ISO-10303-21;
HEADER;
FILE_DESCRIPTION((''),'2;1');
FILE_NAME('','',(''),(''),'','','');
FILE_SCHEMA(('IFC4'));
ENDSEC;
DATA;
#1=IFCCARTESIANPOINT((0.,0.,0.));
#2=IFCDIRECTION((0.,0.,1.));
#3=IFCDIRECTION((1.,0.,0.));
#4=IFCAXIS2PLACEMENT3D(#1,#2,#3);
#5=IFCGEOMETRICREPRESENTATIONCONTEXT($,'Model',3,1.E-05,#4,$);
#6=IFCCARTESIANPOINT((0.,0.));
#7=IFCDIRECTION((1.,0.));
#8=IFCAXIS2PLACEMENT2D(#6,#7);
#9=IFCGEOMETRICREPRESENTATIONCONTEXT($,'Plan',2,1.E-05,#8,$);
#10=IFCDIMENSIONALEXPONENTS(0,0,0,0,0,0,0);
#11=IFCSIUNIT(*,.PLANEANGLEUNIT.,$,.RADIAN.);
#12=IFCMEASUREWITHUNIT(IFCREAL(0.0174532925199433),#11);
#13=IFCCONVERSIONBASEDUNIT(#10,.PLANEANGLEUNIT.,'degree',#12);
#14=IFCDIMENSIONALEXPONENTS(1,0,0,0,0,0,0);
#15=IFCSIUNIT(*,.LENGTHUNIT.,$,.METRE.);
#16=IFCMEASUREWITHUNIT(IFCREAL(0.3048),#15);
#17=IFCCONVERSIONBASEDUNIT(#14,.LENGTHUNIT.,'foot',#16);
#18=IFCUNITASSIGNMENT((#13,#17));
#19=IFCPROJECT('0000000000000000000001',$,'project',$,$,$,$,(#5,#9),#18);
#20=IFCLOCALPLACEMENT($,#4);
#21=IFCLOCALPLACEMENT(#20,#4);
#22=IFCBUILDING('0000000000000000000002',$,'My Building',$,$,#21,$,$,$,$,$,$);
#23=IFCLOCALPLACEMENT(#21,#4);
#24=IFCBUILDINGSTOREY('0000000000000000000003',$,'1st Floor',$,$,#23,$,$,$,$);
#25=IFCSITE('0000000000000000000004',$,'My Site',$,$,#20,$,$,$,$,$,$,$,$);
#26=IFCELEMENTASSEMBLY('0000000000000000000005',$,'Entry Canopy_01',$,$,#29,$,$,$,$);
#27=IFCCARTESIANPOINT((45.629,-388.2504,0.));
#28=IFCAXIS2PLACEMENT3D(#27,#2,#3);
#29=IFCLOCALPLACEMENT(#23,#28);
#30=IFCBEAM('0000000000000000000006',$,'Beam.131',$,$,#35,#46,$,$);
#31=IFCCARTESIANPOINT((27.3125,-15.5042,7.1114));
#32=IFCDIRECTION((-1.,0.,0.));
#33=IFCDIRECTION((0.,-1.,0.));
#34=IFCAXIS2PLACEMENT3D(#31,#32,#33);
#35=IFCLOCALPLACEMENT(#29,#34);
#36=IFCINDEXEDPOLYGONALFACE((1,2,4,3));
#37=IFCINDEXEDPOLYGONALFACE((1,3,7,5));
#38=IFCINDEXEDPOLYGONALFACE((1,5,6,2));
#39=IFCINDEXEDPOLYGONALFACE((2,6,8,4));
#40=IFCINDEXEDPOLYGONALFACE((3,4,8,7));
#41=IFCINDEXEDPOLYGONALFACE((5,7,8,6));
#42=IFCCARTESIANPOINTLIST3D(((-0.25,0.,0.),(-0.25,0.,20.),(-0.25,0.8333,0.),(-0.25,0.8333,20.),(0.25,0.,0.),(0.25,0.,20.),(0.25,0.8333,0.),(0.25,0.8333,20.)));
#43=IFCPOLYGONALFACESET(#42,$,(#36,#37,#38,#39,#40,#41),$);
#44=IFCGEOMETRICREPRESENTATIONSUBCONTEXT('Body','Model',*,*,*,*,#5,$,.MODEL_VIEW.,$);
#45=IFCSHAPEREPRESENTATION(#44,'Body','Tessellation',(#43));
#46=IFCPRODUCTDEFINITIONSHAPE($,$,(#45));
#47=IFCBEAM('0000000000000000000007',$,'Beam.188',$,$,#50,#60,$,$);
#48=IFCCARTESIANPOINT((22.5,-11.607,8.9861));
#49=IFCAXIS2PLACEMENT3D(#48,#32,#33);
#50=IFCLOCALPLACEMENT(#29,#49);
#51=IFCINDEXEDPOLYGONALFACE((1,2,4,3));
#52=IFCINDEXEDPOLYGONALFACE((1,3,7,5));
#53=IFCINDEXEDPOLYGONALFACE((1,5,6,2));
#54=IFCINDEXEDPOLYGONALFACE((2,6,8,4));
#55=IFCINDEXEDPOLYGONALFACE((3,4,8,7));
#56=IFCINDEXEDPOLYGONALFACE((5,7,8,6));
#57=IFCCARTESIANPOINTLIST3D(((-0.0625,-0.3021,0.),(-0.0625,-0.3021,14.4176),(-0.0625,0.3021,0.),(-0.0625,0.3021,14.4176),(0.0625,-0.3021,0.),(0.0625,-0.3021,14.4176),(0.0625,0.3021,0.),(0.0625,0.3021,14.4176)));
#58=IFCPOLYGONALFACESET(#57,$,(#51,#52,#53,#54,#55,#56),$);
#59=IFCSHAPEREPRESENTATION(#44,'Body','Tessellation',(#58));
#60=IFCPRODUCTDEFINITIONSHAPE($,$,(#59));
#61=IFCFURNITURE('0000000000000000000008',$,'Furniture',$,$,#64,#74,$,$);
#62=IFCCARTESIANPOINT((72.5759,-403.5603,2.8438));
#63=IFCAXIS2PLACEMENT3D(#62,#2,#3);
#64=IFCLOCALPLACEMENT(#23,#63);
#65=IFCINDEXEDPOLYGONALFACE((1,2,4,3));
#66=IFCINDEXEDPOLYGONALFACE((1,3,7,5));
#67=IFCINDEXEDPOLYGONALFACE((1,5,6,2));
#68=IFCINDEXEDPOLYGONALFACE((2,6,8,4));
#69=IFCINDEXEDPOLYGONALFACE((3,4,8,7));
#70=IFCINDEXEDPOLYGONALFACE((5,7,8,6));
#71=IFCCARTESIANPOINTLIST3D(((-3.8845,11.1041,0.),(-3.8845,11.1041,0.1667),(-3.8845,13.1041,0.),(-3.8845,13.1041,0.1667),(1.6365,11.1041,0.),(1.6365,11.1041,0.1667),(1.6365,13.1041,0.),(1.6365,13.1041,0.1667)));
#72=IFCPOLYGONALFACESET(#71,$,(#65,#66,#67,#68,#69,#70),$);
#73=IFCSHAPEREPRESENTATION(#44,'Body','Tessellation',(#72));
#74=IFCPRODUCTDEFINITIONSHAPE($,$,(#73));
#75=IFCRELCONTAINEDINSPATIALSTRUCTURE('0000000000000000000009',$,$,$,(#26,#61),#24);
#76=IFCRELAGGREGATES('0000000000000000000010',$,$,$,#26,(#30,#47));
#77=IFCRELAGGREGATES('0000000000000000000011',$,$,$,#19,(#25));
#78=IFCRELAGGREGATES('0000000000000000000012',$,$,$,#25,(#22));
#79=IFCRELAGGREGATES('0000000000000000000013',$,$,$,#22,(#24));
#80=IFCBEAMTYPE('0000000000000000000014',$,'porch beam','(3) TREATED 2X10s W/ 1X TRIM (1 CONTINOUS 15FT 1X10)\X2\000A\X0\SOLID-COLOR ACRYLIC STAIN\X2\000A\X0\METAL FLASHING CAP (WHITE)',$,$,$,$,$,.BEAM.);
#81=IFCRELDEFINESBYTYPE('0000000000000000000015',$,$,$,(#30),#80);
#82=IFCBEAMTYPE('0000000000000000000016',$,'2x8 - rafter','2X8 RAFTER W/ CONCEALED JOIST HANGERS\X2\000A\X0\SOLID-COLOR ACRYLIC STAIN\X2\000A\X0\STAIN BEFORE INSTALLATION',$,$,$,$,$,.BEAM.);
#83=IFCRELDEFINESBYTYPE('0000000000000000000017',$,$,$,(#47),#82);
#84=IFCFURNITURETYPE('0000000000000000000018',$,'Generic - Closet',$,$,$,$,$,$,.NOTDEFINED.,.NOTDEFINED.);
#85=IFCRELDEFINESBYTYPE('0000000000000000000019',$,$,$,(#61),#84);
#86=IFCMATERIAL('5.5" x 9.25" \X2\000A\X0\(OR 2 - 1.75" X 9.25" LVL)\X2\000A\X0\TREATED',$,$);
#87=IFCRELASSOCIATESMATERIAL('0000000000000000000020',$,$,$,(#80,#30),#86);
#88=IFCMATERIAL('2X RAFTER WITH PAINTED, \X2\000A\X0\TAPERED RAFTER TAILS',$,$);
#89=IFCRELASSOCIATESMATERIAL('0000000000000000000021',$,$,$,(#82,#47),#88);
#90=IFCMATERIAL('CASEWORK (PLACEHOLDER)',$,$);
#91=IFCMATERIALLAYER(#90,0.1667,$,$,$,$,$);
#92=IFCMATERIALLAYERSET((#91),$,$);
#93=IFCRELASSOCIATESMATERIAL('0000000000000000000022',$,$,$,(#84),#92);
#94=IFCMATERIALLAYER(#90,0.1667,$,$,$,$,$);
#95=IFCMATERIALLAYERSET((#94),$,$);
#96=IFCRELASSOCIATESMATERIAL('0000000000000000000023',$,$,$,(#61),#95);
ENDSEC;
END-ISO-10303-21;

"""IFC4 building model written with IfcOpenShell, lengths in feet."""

from ifc_helpers import new_model, entity, si_unit, converted_unit, frame, origin_with_axes, origin_2d_with_axis, place, context, subcontext, project, spatial, indexed_curve, rectangle, outline, extrude, material, layer, layer_set, layer_usage, material_profile, profile_set, profile_usage, type_object, element, aggregate, save


model = new_model("IFC4")

# Units and contexts
model_context = context("Model", 3, precision=1e-05, world=origin_with_axes())
plan_context = context("Plan", 2, precision=1e-05, world=origin_2d_with_axis())
body_context = subcontext(model_context, "Body", "Model", "MODEL_VIEW")
ifc_project = project(units=[converted_unit("PLANEANGLEUNIT", "degree", entity("IfcReal", 0.0174532925199433), si_unit("PLANEANGLEUNIT", "RADIAN"), dimensions=[0, 0, 0, 0, 0, 0, 0]), converted_unit("LENGTHUNIT", "foot", entity("IfcReal", 0.3048), si_unit("LENGTHUNIT", "METRE"), dimensions=[1, 0, 0, 0, 0, 0, 0])], contexts=[model_context, plan_context])

# Site, building, storey
site_placement = place(None, origin_with_axes())
site = spatial("IfcSite", under=ifc_project, at=site_placement, Name="My Site")
building_placement = place(site_placement, origin_with_axes())
building = spatial("IfcBuilding", under=site, at=building_placement, Name="My Building")
storey_placement = place(building_placement, origin_with_axes())
storey = spatial("IfcBuildingStorey", under=building, at=storey_placement, Name="1st Floor")

# Element assembly
assembly_1_placement = place(storey_placement, frame((45.629, -388.2504, 0.0), z_axis=(0.0, 0.0, 1.0), x_axis=(1.0, 0.0, 0.0)))
assembly_1 = element("IfcElementAssembly", 1, at=assembly_1_placement, inside=storey, Name="Entry Canopy_01")

# Beam
ifc_material_1 = material(Name="5.5\" x 9.25\" \n(OR 2 - 1.75\" X 9.25\" LVL)\nTREATED")
ifc_material_profile_1 = material_profile(ifc_material_1, rectangle(XDim=0.5, YDim=0.8333))
ifc_profile_set_1 = profile_set([ifc_material_profile_1])
ifc_profile_usage_1 = profile_usage(ifc_profile_set_1, cardinal=2)
beam_type_1 = type_object("IfcBeamType", Name="porch beam", Description="(3) TREATED 2X10s W/ 1X TRIM (1 CONTINOUS 15FT 1X10)\nSOLID-COLOR ACRYLIC STAIN\nMETAL FLASHING CAP (WHITE)", PredefinedType="BEAM", material=ifc_profile_set_1)
beam_1_placement = place(assembly_1_placement, frame((27.3125, -15.5042, 7.1114), z_axis=(-1.0, 0.0, 0.0), x_axis=(0.0, -1.0, 0.0)))
beam_1 = element("IfcBeam", 2, at=beam_1_placement, type_object=beam_type_1, material=ifc_profile_usage_1, Name="Beam.131", context=body_context, shape_type="SweptSolid", body=[
    extrude(rectangle(XDim=0.5, YDim=0.8333), frame((0.0, 0.4167, 0.0), z_axis=(0.0, 0.0, 1.0), x_axis=(1.0, 0.0, 0.0)), (0.0, 0.0, 1.0), 20.0),
])
ifc_material_2 = material(Name="2X RAFTER WITH PAINTED, \nTAPERED RAFTER TAILS")
ifc_material_profile_2 = material_profile(ifc_material_2, rectangle(XDim=0.125, YDim=0.6042))
ifc_profile_set_2 = profile_set([ifc_material_profile_2])
ifc_material_profile_3 = material_profile(ifc_material_2, rectangle(XDim=0.125, YDim=0.6042))
ifc_profile_set_3 = profile_set([ifc_material_profile_3])
beam_type_2 = type_object("IfcBeamType", Name="2x8 - rafter", Description="2X8 RAFTER W/ CONCEALED JOIST HANGERS\nSOLID-COLOR ACRYLIC STAIN\nSTAIN BEFORE INSTALLATION", PredefinedType="BEAM", material=ifc_profile_set_3)

# Beam
ifc_profile_usage_2 = profile_usage(ifc_profile_set_2)
beam_2_placement = place(assembly_1_placement, frame((22.5, -11.607, 8.9861), z_axis=(-1.0, 0.0, 0.0), x_axis=(0.0, -1.0, 0.0)))
beam_2 = element("IfcBeam", 3, at=beam_2_placement, type_object=beam_type_2, material=ifc_profile_usage_2, Name="Beam.188", context=body_context, shape_type="SweptSolid", body=[
    extrude(rectangle(XDim=0.125, YDim=0.6042), origin_with_axes(), (0.0, 0.0, 1.0), 14.4176),
])

aggregate(assembly_1, [beam_1, beam_2])

# Furniture
ifc_material_3 = material(Name="CASEWORK (PLACEHOLDER)")
ifc_layer_1 = layer(ifc_material_3, 0.1667)
ifc_layer_set_1 = layer_set([ifc_layer_1])
ifc_layer_usage_1 = layer_usage(ifc_layer_set_1, "AXIS3", "POSITIVE", 0.0)
ifc_layer_2 = layer(ifc_material_3, 0.1667)
ifc_layer_set_2 = layer_set([ifc_layer_2])
furniture_type = type_object("IfcFurnitureType", Name="Generic - Closet", AssemblyPlace="NOTDEFINED", PredefinedType="NOTDEFINED", material=ifc_layer_set_2)
furniture_placement = place(storey_placement, frame((72.5759, -403.5603, 2.8438), z_axis=(0.0, 0.0, 1.0), x_axis=(1.0, 0.0, 0.0)))
element("IfcFurniture", 4, at=furniture_placement, inside=storey, type_object=furniture_type, material=ifc_layer_usage_1, Name="Furniture", context=body_context, shape_type="SweptSolid", body=[
    extrude(outline(indexed_curve([(1.6365, 11.1041), (-3.8845, 11.1041), (-3.8845, 13.1041), (1.6365, 13.1041), (1.6365, 11.1041)])), None, (0.0, 0.0, 1.0), 0.1667),
])

save(model, "model.ifc")
